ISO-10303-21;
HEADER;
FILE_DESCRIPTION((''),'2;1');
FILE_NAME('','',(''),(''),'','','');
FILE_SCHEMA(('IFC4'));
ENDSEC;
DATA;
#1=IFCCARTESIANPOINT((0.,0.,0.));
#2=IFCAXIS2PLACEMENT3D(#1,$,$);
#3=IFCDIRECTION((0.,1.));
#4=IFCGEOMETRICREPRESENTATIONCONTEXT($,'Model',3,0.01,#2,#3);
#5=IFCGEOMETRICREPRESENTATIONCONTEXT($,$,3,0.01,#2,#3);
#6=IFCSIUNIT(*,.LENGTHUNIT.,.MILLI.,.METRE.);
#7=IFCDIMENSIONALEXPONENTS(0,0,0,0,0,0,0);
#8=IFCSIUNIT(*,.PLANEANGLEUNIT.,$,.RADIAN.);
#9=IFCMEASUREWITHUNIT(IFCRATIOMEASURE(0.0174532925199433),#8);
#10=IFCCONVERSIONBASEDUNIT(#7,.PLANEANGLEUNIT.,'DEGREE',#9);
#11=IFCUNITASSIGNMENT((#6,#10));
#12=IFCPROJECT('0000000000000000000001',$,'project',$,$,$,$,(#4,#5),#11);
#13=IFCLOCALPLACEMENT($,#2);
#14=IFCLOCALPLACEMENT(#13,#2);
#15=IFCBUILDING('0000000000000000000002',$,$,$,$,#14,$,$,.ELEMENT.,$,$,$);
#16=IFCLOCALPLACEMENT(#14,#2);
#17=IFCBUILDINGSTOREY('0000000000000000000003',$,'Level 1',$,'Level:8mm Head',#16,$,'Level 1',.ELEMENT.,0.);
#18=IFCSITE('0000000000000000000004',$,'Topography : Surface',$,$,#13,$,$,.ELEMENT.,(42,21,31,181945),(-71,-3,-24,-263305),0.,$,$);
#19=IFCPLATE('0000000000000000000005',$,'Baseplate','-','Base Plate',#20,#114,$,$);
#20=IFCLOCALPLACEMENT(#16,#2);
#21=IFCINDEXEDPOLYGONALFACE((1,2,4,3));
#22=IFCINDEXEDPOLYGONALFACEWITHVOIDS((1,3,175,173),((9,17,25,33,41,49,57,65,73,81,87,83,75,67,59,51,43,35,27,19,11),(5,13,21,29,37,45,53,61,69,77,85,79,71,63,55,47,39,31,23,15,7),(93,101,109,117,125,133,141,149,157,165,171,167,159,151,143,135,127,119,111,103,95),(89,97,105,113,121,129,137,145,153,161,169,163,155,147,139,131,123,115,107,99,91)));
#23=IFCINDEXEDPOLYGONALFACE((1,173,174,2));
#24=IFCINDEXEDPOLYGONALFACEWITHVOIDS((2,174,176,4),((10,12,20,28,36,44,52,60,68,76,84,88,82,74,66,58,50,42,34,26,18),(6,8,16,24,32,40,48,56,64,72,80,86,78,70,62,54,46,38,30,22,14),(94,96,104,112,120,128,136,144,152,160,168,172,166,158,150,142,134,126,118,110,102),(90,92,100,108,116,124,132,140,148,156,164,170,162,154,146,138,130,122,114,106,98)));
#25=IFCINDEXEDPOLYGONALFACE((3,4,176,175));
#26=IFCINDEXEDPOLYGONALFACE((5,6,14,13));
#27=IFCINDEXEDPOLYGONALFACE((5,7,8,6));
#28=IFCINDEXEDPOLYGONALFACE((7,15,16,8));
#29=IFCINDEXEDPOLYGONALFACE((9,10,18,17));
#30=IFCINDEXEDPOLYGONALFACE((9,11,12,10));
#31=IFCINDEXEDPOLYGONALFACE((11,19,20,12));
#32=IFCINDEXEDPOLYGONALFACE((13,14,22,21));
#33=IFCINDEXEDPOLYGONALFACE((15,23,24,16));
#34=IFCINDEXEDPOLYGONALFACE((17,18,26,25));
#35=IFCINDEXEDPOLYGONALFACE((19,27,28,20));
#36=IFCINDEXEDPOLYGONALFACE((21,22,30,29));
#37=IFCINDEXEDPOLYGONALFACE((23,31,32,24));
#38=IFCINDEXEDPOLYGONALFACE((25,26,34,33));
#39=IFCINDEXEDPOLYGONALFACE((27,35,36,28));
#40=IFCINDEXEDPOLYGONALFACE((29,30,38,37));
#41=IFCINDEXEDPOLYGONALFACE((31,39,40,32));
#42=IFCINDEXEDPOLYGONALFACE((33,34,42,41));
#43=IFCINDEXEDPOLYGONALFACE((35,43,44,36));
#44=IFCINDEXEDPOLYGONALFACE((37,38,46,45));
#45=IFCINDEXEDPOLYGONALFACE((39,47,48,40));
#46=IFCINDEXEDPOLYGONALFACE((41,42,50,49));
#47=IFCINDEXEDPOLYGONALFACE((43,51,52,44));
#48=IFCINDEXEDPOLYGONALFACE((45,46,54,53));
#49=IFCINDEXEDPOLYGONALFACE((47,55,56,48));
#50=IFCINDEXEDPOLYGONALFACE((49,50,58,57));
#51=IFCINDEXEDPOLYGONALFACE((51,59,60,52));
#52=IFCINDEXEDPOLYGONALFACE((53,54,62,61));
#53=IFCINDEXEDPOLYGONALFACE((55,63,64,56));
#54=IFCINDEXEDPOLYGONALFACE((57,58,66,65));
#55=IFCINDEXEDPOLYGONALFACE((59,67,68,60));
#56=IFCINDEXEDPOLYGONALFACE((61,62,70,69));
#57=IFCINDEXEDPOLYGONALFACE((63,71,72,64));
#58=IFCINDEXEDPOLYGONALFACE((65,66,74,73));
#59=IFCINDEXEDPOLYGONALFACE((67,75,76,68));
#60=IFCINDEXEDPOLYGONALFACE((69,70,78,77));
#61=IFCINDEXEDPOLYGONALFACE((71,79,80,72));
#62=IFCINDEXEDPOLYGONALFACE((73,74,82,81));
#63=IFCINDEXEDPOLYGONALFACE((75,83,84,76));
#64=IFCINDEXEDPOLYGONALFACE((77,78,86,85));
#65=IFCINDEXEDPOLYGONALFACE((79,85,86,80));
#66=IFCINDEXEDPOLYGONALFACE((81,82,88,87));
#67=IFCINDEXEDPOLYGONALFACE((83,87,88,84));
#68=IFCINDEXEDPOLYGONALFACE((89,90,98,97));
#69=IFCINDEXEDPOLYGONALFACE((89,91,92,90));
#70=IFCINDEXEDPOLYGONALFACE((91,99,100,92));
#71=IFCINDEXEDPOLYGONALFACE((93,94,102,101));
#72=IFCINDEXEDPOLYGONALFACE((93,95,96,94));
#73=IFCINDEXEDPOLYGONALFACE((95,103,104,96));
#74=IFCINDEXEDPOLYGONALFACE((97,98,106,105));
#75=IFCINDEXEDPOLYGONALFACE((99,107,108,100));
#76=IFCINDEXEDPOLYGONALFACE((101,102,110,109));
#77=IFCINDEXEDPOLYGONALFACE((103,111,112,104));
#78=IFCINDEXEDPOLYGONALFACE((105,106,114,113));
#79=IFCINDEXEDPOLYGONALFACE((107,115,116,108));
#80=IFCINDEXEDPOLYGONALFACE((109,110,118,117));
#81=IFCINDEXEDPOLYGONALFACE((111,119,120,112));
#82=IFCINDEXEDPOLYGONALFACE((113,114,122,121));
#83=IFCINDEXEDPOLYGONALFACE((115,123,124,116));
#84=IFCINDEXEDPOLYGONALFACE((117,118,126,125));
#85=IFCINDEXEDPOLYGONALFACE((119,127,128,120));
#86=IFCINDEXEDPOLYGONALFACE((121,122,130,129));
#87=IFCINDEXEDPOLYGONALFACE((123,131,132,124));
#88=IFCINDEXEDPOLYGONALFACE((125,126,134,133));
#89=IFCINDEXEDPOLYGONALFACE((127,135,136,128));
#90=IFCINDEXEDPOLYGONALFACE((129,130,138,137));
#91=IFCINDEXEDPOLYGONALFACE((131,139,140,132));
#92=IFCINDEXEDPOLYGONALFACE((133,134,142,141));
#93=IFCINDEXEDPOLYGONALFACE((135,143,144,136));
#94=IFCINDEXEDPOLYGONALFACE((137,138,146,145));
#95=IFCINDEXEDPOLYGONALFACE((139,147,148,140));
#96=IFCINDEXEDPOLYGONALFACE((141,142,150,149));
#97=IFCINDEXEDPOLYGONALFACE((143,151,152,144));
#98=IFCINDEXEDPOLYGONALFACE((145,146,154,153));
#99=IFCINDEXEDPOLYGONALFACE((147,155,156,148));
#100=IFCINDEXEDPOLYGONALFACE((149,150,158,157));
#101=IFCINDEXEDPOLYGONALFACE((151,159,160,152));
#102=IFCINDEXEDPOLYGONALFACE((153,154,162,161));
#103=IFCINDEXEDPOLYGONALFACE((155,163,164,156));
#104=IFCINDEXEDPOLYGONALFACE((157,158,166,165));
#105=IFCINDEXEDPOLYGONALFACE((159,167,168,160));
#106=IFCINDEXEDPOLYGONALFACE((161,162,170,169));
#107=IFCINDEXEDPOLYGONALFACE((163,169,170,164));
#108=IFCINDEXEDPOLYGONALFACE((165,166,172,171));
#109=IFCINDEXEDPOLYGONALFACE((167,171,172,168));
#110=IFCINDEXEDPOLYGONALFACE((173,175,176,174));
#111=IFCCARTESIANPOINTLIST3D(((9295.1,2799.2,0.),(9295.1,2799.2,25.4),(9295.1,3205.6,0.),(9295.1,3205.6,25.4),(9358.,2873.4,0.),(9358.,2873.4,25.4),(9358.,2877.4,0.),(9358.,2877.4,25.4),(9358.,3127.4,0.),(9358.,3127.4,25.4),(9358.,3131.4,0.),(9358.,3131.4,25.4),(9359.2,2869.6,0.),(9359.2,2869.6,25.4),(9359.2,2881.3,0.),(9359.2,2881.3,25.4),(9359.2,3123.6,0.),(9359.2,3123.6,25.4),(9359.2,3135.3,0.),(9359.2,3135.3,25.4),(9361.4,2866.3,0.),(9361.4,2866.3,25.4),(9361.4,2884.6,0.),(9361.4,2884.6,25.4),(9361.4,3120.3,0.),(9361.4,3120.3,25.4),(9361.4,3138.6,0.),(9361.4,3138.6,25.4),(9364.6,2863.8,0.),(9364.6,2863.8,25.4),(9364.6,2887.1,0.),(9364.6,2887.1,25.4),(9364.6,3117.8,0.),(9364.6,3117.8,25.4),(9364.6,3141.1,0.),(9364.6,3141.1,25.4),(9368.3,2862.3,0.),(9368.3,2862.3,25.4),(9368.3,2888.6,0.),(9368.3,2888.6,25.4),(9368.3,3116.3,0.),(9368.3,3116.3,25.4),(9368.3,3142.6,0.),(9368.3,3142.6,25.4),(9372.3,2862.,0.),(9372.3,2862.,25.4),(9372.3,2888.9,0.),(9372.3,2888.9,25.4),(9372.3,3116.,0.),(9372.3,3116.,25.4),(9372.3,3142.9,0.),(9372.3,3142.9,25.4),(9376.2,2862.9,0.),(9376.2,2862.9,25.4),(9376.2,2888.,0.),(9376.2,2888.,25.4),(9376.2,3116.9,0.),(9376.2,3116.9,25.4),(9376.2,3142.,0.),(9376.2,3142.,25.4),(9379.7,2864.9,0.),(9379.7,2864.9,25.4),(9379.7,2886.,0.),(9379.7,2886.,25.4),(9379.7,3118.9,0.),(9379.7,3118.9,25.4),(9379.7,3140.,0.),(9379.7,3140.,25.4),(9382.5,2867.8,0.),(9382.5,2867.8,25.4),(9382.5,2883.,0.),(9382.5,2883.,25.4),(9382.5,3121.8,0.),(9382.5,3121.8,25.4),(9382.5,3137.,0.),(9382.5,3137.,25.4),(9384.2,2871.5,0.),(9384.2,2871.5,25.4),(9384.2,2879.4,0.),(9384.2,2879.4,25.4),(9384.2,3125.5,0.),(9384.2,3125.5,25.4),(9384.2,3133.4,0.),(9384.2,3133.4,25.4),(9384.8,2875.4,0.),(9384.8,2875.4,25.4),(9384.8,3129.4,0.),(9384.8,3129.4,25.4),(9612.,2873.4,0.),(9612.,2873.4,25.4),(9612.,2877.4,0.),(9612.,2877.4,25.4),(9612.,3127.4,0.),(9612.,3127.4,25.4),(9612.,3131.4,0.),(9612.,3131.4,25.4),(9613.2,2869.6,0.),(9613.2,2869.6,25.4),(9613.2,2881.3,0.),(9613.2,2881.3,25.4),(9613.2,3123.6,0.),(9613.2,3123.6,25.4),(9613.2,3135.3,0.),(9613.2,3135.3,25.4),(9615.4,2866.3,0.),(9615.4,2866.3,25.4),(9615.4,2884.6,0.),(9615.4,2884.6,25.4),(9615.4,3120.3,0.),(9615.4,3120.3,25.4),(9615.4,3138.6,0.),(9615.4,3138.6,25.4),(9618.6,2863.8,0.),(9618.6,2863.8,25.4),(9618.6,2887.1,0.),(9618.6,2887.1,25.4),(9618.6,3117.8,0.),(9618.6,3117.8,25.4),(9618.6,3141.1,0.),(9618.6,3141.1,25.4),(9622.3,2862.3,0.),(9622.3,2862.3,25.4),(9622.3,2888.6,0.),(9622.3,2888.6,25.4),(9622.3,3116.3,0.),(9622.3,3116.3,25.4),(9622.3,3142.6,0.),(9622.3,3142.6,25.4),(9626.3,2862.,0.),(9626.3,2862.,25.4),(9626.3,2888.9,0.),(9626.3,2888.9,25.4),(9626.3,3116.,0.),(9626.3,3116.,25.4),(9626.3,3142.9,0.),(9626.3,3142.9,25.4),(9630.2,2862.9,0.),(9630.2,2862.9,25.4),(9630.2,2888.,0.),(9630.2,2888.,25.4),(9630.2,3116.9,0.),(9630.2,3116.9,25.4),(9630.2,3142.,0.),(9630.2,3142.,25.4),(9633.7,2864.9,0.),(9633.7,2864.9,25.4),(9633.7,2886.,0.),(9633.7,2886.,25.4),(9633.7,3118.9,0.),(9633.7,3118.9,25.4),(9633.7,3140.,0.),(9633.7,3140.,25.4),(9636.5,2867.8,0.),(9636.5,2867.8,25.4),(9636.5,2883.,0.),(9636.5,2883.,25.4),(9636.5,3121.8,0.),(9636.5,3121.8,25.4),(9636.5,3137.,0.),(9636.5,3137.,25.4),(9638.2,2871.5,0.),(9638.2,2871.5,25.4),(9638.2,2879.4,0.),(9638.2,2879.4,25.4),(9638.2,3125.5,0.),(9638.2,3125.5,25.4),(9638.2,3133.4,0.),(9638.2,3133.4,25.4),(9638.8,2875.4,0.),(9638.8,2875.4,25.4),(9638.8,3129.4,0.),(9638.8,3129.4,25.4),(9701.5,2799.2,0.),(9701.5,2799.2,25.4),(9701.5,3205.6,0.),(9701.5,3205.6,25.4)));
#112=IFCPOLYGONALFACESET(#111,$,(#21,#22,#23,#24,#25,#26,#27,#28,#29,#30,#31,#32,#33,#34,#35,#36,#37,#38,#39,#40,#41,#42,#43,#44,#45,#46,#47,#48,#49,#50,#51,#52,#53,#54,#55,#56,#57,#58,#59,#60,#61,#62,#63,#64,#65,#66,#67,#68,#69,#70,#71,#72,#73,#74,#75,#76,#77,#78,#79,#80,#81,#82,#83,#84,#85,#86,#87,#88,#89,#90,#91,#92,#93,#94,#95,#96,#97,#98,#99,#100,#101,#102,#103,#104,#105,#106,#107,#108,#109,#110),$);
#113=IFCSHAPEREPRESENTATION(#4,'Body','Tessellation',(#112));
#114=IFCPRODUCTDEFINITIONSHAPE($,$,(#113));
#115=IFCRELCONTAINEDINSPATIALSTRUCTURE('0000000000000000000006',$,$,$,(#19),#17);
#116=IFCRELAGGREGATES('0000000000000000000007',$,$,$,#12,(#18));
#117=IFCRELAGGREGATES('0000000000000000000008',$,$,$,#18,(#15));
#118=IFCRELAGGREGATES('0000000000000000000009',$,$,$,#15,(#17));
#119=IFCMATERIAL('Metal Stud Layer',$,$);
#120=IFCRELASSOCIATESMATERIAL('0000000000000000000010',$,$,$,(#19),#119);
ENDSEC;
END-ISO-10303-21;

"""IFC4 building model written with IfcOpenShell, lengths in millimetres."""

from ifc_helpers import new_model, entity, si_unit, converted_unit, direction, frame, frame_2d, origin, origin_with_axes, place, context, project, spatial, polyline, circle, outline, extrude, material, element, save


model = new_model("IFC4")

# Units and contexts
model_context = context("Model", 3, precision=0.01, world=origin(), true_north=direction((0.0, 1.0)))
context_of_model = context(None, 3, precision=0.01, world=origin(), true_north=direction((0.0, 1.0)))
ifc_project = project(units=[si_unit("LENGTHUNIT", "METRE", prefix="MILLI"), converted_unit("PLANEANGLEUNIT", "DEGREE", entity("IfcRatioMeasure", 0.0174532925199433), si_unit("PLANEANGLEUNIT", "RADIAN"), dimensions=[0, 0, 0, 0, 0, 0, 0])], contexts=[model_context, context_of_model])

# Site, building, storey
site_placement = place(None, origin())
site = spatial("IfcSite", under=ifc_project, at=site_placement, Name="Topography : Surface", CompositionType="ELEMENT", RefLatitude=(42, 21, 31, 181945), RefLongitude=(-71, -3, -24, -263305), RefElevation=0.0)
building_placement = place(site_placement, origin())
building = spatial("IfcBuilding", under=site, at=building_placement, CompositionType="ELEMENT")
storey_placement = place(building_placement, origin())
storey = spatial("IfcBuildingStorey", under=building, at=storey_placement, Name="Level 1", ObjectType="Level:8mm Head", LongName="Level 1", CompositionType="ELEMENT", Elevation=0.0)

# Plate, openings
ifc_material_1 = material(Name="Metal Stud Layer")
plate_1_placement = place(storey_placement, frame((9295.1, 3205.6, 25.4), z_axis=(0.0, 0.0, -1.0), x_axis=(1.0, 0.0, 0.0)))
plate_1 = element("IfcPlate", 1, at=plate_1_placement, inside=storey, material=ifc_material_1, Name="Baseplate", Description="-", ObjectType="Base Plate", context=model_context, shape_type="SweptSolid", body=[
    extrude(outline(polyline([(0.0, 0.0), (406.4, 0.0), (406.4, 406.4), (0.0, 406.4), (0.0, 0.0)])), origin_with_axes(), (0.0, 0.0, 1.0), 25.4),
])
opening_1_placement = place(plate_1_placement, frame((203.2, 203.2, 25.9), z_axis=(0.0, 0.0, -1.0), x_axis=(1.0, 0.0, 0.0)))
element("IfcOpeningElement", 2, at=opening_1_placement, cuts=plate_1, ObjectType="Opening", context=model_context, shape_type="SweptSolid", body=[
    extrude(circle(Radius=13.5, at=frame_2d((127.0, 127.0), x_axis=(1.0, 0.0))), origin(), (0.0, 0.0, 1.0), 26.4),
])
opening_2_placement = place(plate_1_placement, frame((203.2, 203.2, 25.9), z_axis=(0.0, 0.0, -1.0), x_axis=(1.0, 0.0, 0.0)))
element("IfcOpeningElement", 3, at=opening_2_placement, cuts=plate_1, ObjectType="Opening", context=model_context, shape_type="SweptSolid", body=[
    extrude(circle(Radius=13.5, at=frame_2d((-127.0, 127.0), x_axis=(1.0, 0.0))), origin(), (0.0, 0.0, 1.0), 26.4),
])
opening_3_placement = place(plate_1_placement, frame((203.2, 203.2, 25.9), z_axis=(0.0, 0.0, -1.0), x_axis=(1.0, 0.0, 0.0)))
element("IfcOpeningElement", 4, at=opening_3_placement, cuts=plate_1, ObjectType="Opening", context=model_context, shape_type="SweptSolid", body=[
    extrude(circle(Radius=13.5, at=frame_2d((127.0, -127.0), x_axis=(1.0, 0.0))), origin(), (0.0, 0.0, 1.0), 26.4),
])
opening_4_placement = place(plate_1_placement, frame((203.2, 203.2, 25.9), z_axis=(0.0, 0.0, -1.0), x_axis=(1.0, 0.0, 0.0)))
element("IfcOpeningElement", 5, at=opening_4_placement, cuts=plate_1, ObjectType="Opening", context=model_context, shape_type="SweptSolid", body=[
    extrude(circle(Radius=13.5, at=frame_2d((-127.0, -127.0), x_axis=(1.0, 0.0))), origin(), (0.0, 0.0, 1.0), 26.4),
])

save(model, "model.ifc")
